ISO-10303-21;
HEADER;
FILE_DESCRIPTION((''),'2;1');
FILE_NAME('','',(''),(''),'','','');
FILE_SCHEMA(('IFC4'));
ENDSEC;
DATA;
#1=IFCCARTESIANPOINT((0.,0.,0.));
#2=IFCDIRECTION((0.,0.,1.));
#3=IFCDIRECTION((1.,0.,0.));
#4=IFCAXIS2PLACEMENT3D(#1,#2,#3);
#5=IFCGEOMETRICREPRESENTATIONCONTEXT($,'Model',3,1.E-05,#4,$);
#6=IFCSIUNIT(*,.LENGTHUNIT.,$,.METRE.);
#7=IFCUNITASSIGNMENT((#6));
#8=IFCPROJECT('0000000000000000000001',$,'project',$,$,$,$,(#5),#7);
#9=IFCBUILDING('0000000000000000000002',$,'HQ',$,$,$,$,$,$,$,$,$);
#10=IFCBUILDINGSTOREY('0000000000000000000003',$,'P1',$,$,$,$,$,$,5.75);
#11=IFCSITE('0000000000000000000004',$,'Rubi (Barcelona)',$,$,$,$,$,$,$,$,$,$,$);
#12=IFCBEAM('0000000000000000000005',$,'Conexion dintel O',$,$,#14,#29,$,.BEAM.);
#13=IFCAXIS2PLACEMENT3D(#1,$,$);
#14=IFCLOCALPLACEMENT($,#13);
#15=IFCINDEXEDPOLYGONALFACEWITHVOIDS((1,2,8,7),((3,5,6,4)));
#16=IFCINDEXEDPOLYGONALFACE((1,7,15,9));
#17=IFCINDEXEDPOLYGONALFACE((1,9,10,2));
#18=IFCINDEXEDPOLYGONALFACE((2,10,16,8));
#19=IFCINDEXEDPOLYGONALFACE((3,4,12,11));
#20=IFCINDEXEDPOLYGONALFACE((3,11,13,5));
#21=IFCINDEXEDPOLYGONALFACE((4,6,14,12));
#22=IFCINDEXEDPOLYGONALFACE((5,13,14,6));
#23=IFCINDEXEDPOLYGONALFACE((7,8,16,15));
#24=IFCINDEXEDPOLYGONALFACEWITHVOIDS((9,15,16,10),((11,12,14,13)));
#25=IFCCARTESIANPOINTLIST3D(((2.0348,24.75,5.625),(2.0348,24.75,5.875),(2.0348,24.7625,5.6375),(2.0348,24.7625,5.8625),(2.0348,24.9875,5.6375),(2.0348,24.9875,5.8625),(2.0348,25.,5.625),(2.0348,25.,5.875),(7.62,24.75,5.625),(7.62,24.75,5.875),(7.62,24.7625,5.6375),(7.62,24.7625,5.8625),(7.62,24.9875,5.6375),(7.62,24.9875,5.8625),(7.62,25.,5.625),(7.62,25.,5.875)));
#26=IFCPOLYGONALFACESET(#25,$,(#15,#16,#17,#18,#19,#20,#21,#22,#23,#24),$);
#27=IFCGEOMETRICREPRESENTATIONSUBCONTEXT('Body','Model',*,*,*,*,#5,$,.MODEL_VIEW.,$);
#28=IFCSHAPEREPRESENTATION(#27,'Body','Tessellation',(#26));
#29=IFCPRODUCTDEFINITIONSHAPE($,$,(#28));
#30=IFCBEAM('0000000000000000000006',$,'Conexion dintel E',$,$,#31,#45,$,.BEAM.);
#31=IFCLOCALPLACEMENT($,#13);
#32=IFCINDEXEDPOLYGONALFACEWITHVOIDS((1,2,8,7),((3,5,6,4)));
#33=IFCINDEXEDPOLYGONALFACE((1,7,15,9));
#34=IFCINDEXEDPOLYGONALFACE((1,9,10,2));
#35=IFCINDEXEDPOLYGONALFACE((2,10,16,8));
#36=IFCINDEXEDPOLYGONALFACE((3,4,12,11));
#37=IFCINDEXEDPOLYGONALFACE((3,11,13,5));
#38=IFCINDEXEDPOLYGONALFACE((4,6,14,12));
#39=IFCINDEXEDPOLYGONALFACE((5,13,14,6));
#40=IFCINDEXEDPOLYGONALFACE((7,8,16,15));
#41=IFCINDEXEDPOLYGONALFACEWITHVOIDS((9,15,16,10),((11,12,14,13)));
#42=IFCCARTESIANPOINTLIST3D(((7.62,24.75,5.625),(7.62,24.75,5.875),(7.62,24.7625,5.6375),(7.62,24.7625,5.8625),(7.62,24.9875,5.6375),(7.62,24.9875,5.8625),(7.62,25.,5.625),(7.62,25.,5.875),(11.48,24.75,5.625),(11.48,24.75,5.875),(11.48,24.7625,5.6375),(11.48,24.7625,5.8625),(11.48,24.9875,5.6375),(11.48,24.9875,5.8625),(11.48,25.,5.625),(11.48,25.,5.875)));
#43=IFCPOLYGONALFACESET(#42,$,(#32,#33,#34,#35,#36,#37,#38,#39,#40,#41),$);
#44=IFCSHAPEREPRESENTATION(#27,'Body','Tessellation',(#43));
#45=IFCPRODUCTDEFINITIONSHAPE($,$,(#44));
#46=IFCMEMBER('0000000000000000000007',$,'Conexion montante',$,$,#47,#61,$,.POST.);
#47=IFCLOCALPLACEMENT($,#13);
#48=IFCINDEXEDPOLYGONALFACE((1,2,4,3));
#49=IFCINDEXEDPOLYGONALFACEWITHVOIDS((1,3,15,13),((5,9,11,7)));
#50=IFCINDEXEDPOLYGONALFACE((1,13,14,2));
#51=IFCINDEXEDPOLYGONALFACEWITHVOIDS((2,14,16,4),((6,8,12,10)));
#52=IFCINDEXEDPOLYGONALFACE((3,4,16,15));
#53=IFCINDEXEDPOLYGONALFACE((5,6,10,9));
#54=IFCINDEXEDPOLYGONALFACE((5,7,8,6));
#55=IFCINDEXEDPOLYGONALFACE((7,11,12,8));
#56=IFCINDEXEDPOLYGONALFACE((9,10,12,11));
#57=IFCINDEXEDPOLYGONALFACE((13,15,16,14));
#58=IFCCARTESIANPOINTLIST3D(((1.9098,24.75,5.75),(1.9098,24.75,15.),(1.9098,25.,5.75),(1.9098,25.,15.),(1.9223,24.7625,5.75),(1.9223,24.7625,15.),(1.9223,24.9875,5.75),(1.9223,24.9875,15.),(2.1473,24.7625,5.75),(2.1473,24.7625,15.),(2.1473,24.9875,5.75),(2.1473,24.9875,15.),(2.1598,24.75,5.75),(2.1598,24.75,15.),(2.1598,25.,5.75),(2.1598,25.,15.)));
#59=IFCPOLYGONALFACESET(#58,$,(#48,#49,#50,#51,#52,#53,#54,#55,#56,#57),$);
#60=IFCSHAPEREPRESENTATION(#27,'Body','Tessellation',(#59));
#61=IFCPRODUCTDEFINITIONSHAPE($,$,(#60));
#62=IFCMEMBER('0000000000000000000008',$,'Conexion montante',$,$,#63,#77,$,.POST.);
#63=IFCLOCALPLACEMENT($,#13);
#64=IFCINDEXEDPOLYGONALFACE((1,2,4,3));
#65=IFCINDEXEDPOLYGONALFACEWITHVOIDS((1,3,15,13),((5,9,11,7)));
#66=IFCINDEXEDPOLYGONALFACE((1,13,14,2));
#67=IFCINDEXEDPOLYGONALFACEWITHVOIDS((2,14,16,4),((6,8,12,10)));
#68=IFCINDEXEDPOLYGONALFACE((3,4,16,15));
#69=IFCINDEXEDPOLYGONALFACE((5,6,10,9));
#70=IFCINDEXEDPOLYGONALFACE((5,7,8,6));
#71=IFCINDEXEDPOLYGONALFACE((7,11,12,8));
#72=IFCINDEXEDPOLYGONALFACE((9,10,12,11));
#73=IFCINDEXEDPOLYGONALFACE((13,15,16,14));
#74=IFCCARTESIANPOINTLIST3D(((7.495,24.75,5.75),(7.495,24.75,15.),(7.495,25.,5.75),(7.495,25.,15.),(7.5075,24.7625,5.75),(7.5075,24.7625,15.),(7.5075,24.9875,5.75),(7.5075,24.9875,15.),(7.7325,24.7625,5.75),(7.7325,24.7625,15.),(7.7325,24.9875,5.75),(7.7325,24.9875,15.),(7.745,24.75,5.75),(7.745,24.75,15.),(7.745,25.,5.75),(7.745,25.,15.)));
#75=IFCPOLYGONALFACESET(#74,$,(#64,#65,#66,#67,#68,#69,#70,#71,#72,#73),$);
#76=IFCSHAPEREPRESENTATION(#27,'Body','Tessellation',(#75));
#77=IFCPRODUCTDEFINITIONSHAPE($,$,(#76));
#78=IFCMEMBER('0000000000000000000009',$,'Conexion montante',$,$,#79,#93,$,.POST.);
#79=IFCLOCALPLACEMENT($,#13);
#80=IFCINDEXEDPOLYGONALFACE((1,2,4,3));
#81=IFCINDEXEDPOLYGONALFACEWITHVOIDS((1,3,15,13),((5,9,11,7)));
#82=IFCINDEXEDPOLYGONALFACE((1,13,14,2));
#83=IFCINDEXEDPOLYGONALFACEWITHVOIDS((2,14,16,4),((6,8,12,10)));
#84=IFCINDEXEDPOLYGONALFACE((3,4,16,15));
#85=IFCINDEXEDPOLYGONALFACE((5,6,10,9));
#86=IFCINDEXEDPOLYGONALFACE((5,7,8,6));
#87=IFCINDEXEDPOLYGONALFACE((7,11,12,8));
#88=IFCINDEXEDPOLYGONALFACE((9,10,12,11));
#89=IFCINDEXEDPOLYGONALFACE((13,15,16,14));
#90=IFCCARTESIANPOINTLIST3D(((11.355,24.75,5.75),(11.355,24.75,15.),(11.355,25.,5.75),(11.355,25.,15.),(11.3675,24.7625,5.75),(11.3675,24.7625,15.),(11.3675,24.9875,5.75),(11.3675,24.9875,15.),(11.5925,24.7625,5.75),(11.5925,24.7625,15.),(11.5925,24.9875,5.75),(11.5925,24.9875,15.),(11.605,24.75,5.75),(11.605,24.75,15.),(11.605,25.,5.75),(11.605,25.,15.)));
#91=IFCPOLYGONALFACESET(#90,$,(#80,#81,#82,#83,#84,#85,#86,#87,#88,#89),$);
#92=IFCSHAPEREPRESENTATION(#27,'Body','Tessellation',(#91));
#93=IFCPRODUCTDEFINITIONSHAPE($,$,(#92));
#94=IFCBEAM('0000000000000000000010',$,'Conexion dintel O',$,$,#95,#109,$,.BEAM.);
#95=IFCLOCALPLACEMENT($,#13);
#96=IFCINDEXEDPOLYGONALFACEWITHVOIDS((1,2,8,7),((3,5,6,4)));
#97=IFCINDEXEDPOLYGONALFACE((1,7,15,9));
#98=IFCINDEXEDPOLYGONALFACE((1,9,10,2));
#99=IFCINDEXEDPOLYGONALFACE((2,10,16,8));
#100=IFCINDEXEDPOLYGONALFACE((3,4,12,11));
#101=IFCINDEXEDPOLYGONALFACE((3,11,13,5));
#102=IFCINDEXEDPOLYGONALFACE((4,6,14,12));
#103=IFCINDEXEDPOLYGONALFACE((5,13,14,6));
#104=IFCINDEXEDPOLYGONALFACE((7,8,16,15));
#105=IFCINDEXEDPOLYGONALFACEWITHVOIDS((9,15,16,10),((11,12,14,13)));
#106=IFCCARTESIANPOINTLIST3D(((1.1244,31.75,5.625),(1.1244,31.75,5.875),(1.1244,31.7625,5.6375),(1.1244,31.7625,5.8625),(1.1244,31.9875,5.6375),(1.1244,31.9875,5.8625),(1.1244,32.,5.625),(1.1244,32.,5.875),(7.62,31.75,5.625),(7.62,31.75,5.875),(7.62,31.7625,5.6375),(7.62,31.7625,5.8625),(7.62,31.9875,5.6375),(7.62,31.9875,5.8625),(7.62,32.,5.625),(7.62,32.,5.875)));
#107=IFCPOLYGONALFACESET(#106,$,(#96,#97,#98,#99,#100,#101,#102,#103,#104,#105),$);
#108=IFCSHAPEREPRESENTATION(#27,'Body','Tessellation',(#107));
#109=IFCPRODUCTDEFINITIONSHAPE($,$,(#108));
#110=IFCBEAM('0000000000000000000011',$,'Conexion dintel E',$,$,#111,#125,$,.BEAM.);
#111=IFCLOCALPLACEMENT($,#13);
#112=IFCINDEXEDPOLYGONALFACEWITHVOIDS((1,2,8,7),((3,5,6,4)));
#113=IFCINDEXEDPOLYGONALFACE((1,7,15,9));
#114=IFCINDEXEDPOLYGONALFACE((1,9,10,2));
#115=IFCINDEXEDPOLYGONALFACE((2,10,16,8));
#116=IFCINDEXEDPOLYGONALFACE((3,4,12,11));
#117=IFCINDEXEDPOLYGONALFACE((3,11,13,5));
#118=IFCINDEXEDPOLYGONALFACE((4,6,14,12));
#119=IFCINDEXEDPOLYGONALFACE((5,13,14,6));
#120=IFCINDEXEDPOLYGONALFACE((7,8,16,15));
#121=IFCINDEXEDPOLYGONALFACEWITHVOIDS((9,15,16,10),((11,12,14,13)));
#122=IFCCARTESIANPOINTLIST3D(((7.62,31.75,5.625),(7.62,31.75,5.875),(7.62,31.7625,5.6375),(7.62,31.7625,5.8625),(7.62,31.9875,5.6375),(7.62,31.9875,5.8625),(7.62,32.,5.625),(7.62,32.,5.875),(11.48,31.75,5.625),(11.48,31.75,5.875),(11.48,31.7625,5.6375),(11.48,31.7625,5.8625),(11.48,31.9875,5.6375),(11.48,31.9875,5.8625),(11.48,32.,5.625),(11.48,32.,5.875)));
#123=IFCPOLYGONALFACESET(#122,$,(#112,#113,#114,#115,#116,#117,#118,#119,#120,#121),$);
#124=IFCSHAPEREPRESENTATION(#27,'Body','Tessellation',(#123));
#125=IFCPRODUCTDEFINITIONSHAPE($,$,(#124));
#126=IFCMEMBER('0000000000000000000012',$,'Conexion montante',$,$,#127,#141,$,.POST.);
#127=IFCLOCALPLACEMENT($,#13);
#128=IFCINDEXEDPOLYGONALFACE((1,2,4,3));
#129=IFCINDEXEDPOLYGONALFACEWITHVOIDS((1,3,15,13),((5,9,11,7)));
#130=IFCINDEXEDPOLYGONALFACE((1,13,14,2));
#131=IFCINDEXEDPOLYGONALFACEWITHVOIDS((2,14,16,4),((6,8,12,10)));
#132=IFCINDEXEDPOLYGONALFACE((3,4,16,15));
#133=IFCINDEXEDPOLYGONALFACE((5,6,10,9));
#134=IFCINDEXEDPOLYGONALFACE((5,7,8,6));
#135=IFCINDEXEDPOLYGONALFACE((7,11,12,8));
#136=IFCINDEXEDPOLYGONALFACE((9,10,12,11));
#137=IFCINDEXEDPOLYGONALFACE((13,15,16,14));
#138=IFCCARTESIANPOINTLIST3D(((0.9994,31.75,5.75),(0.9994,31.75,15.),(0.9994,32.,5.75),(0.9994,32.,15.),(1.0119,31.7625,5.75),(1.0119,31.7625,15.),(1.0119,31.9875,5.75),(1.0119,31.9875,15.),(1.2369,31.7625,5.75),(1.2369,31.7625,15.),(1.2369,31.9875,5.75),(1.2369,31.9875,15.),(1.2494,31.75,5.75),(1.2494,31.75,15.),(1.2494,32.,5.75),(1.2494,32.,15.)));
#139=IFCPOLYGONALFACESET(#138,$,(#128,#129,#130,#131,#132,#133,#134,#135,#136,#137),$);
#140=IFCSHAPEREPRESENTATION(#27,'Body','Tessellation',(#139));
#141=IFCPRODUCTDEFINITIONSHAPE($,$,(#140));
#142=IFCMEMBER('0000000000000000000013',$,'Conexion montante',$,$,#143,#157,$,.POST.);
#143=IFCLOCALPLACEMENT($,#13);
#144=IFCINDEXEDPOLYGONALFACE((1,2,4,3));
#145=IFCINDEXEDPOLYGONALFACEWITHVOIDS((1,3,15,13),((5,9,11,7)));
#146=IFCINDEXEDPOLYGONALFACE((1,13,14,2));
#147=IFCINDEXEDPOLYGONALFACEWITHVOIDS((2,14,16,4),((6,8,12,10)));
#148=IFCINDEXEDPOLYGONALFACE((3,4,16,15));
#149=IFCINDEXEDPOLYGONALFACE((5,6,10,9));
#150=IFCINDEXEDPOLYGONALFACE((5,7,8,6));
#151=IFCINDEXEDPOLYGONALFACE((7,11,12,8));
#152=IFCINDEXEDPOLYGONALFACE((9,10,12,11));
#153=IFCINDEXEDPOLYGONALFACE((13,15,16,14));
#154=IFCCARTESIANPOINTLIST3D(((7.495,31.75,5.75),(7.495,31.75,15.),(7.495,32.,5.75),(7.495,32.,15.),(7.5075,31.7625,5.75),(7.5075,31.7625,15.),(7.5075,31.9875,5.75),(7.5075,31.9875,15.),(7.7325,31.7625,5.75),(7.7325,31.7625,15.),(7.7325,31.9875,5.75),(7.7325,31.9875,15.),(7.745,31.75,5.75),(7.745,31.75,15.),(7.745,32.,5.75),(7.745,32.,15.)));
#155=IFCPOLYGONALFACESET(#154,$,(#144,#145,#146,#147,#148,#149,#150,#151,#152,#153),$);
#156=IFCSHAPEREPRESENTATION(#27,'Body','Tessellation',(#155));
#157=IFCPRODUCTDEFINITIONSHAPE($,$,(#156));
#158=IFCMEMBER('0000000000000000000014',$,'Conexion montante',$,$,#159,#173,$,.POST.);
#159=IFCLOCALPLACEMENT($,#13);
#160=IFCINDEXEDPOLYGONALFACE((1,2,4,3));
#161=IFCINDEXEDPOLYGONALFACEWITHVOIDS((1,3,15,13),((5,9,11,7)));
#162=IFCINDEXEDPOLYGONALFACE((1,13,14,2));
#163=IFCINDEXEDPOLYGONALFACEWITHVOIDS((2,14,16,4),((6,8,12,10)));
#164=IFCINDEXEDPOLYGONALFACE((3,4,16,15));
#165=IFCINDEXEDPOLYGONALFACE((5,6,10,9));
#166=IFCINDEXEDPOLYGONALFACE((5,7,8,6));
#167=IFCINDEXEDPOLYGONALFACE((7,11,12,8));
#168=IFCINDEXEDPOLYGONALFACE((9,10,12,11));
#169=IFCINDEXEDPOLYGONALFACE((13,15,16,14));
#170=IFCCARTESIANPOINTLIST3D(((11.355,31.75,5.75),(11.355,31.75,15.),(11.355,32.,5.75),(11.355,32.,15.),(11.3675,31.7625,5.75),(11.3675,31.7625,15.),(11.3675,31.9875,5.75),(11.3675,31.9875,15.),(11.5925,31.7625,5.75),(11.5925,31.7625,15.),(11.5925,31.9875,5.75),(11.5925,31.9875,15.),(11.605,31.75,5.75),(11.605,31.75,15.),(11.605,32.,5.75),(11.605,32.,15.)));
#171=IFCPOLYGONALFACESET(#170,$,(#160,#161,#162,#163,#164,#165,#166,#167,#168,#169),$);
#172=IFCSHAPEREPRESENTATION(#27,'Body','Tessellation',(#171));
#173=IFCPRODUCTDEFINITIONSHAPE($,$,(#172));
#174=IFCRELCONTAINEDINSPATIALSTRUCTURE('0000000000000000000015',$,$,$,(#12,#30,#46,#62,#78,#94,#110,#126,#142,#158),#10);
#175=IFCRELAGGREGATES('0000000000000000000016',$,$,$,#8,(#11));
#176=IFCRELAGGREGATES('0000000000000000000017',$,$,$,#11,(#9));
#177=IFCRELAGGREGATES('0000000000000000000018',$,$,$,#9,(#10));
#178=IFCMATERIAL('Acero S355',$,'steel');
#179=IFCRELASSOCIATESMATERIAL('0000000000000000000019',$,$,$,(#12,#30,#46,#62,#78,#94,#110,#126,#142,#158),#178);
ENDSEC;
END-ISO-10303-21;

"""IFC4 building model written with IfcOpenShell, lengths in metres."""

from ifc_helpers import new_model, si_unit, frame, origin_with_axes, place, context, subcontext, project, spatial, hollow_rectangle, extrude, material, element, save


model = new_model("IFC4")

# Units and contexts
model_context = context("Model", 3, precision=1e-05, world=origin_with_axes())
body_context = subcontext(model_context, "Body", "Model", "MODEL_VIEW")
ifc_project = project(units=[si_unit("LENGTHUNIT", "METRE")], contexts=[model_context])

# Site, building, storey
site = spatial("IfcSite", under=ifc_project, Name="Rubi (Barcelona)")
building = spatial("IfcBuilding", under=site, Name="HQ")
storey = spatial("IfcBuildingStorey", under=building, Name="P1", Elevation=5.75)

# Shared definitions
ifc_material = material(Name="Acero S355", Category="steel")

# Beams
beam_1_placement = place(None, origin_with_axes())
element("IfcBeam", 1, at=beam_1_placement, inside=storey, material=ifc_material, Name="Conexion dintel O", PredefinedType="BEAM", context=body_context, shape_type="SweptSolid", body=[
    extrude(hollow_rectangle(XDim=0.25, YDim=0.25, WallThickness=0.0125), frame((2.0348, 24.875, 5.75), z_axis=(1.0, 0.0, 0.0), x_axis=(0.0, 1.0, 0.0)), (0.0, 0.0, 1.0), 5.5852),
])
beam_2_placement = place(None, origin_with_axes())
element("IfcBeam", 2, at=beam_2_placement, inside=storey, material=ifc_material, Name="Conexion dintel E", PredefinedType="BEAM", context=body_context, shape_type="SweptSolid", body=[
    extrude(hollow_rectangle(XDim=0.25, YDim=0.25, WallThickness=0.0125), frame((7.62, 24.875, 5.75), z_axis=(1.0, 0.0, 0.0), x_axis=(0.0, 1.0, 0.0)), (0.0, 0.0, 1.0), 3.86),
])

# Members
member_1_placement = place(None, origin_with_axes())
element("IfcMember", 3, at=member_1_placement, inside=storey, material=ifc_material, Name="Conexion montante", PredefinedType="POST", context=body_context, shape_type="SweptSolid", body=[
    extrude(hollow_rectangle(XDim=0.25, YDim=0.25, WallThickness=0.0125), frame((2.0348, 24.875, 5.75), z_axis=(0.0, 0.0, 1.0), x_axis=(1.0, 0.0, 0.0)), (0.0, 0.0, 1.0), 9.25),
])
member_2_placement = place(None, origin_with_axes())
element("IfcMember", 4, at=member_2_placement, inside=storey, material=ifc_material, Name="Conexion montante", PredefinedType="POST", context=body_context, shape_type="SweptSolid", body=[
    extrude(hollow_rectangle(XDim=0.25, YDim=0.25, WallThickness=0.0125), frame((7.62, 24.875, 5.75), z_axis=(0.0, 0.0, 1.0), x_axis=(1.0, 0.0, 0.0)), (0.0, 0.0, 1.0), 9.25),
])
member_3_placement = place(None, origin_with_axes())
element("IfcMember", 5, at=member_3_placement, inside=storey, material=ifc_material, Name="Conexion montante", PredefinedType="POST", context=body_context, shape_type="SweptSolid", body=[
    extrude(hollow_rectangle(XDim=0.25, YDim=0.25, WallThickness=0.0125), frame((11.48, 24.875, 5.75), z_axis=(0.0, 0.0, 1.0), x_axis=(1.0, 0.0, 0.0)), (0.0, 0.0, 1.0), 9.25),
])

# Beams
beam_3_placement = place(None, origin_with_axes())
element("IfcBeam", 6, at=beam_3_placement, inside=storey, material=ifc_material, Name="Conexion dintel O", PredefinedType="BEAM", context=body_context, shape_type="SweptSolid", body=[
    extrude(hollow_rectangle(XDim=0.25, YDim=0.25, WallThickness=0.0125), frame((1.1244, 31.875, 5.75), z_axis=(1.0, 0.0, 0.0), x_axis=(0.0, 1.0, 0.0)), (0.0, 0.0, 1.0), 6.4956),
])
beam_4_placement = place(None, origin_with_axes())
element("IfcBeam", 7, at=beam_4_placement, inside=storey, material=ifc_material, Name="Conexion dintel E", PredefinedType="BEAM", context=body_context, shape_type="SweptSolid", body=[
    extrude(hollow_rectangle(XDim=0.25, YDim=0.25, WallThickness=0.0125), frame((7.62, 31.875, 5.75), z_axis=(1.0, 0.0, 0.0), x_axis=(0.0, 1.0, 0.0)), (0.0, 0.0, 1.0), 3.86),
])

# Members
member_4_placement = place(None, origin_with_axes())
element("IfcMember", 8, at=member_4_placement, inside=storey, material=ifc_material, Name="Conexion montante", PredefinedType="POST", context=body_context, shape_type="SweptSolid", body=[
    extrude(hollow_rectangle(XDim=0.25, YDim=0.25, WallThickness=0.0125), frame((1.1244, 31.875, 5.75), z_axis=(0.0, 0.0, 1.0), x_axis=(1.0, 0.0, 0.0)), (0.0, 0.0, 1.0), 9.25),
])
member_5_placement = place(None, origin_with_axes())
element("IfcMember", 9, at=member_5_placement, inside=storey, material=ifc_material, Name="Conexion montante", PredefinedType="POST", context=body_context, shape_type="SweptSolid", body=[
    extrude(hollow_rectangle(XDim=0.25, YDim=0.25, WallThickness=0.0125), frame((7.62, 31.875, 5.75), z_axis=(0.0, 0.0, 1.0), x_axis=(1.0, 0.0, 0.0)), (0.0, 0.0, 1.0), 9.25),
])
member_6_placement = place(None, origin_with_axes())
element("IfcMember", 10, at=member_6_placement, inside=storey, material=ifc_material, Name="Conexion montante", PredefinedType="POST", context=body_context, shape_type="SweptSolid", body=[
    extrude(hollow_rectangle(XDim=0.25, YDim=0.25, WallThickness=0.0125), frame((11.48, 31.875, 5.75), z_axis=(0.0, 0.0, 1.0), x_axis=(1.0, 0.0, 0.0)), (0.0, 0.0, 1.0), 9.25),
])

save(model, "model.ifc")
